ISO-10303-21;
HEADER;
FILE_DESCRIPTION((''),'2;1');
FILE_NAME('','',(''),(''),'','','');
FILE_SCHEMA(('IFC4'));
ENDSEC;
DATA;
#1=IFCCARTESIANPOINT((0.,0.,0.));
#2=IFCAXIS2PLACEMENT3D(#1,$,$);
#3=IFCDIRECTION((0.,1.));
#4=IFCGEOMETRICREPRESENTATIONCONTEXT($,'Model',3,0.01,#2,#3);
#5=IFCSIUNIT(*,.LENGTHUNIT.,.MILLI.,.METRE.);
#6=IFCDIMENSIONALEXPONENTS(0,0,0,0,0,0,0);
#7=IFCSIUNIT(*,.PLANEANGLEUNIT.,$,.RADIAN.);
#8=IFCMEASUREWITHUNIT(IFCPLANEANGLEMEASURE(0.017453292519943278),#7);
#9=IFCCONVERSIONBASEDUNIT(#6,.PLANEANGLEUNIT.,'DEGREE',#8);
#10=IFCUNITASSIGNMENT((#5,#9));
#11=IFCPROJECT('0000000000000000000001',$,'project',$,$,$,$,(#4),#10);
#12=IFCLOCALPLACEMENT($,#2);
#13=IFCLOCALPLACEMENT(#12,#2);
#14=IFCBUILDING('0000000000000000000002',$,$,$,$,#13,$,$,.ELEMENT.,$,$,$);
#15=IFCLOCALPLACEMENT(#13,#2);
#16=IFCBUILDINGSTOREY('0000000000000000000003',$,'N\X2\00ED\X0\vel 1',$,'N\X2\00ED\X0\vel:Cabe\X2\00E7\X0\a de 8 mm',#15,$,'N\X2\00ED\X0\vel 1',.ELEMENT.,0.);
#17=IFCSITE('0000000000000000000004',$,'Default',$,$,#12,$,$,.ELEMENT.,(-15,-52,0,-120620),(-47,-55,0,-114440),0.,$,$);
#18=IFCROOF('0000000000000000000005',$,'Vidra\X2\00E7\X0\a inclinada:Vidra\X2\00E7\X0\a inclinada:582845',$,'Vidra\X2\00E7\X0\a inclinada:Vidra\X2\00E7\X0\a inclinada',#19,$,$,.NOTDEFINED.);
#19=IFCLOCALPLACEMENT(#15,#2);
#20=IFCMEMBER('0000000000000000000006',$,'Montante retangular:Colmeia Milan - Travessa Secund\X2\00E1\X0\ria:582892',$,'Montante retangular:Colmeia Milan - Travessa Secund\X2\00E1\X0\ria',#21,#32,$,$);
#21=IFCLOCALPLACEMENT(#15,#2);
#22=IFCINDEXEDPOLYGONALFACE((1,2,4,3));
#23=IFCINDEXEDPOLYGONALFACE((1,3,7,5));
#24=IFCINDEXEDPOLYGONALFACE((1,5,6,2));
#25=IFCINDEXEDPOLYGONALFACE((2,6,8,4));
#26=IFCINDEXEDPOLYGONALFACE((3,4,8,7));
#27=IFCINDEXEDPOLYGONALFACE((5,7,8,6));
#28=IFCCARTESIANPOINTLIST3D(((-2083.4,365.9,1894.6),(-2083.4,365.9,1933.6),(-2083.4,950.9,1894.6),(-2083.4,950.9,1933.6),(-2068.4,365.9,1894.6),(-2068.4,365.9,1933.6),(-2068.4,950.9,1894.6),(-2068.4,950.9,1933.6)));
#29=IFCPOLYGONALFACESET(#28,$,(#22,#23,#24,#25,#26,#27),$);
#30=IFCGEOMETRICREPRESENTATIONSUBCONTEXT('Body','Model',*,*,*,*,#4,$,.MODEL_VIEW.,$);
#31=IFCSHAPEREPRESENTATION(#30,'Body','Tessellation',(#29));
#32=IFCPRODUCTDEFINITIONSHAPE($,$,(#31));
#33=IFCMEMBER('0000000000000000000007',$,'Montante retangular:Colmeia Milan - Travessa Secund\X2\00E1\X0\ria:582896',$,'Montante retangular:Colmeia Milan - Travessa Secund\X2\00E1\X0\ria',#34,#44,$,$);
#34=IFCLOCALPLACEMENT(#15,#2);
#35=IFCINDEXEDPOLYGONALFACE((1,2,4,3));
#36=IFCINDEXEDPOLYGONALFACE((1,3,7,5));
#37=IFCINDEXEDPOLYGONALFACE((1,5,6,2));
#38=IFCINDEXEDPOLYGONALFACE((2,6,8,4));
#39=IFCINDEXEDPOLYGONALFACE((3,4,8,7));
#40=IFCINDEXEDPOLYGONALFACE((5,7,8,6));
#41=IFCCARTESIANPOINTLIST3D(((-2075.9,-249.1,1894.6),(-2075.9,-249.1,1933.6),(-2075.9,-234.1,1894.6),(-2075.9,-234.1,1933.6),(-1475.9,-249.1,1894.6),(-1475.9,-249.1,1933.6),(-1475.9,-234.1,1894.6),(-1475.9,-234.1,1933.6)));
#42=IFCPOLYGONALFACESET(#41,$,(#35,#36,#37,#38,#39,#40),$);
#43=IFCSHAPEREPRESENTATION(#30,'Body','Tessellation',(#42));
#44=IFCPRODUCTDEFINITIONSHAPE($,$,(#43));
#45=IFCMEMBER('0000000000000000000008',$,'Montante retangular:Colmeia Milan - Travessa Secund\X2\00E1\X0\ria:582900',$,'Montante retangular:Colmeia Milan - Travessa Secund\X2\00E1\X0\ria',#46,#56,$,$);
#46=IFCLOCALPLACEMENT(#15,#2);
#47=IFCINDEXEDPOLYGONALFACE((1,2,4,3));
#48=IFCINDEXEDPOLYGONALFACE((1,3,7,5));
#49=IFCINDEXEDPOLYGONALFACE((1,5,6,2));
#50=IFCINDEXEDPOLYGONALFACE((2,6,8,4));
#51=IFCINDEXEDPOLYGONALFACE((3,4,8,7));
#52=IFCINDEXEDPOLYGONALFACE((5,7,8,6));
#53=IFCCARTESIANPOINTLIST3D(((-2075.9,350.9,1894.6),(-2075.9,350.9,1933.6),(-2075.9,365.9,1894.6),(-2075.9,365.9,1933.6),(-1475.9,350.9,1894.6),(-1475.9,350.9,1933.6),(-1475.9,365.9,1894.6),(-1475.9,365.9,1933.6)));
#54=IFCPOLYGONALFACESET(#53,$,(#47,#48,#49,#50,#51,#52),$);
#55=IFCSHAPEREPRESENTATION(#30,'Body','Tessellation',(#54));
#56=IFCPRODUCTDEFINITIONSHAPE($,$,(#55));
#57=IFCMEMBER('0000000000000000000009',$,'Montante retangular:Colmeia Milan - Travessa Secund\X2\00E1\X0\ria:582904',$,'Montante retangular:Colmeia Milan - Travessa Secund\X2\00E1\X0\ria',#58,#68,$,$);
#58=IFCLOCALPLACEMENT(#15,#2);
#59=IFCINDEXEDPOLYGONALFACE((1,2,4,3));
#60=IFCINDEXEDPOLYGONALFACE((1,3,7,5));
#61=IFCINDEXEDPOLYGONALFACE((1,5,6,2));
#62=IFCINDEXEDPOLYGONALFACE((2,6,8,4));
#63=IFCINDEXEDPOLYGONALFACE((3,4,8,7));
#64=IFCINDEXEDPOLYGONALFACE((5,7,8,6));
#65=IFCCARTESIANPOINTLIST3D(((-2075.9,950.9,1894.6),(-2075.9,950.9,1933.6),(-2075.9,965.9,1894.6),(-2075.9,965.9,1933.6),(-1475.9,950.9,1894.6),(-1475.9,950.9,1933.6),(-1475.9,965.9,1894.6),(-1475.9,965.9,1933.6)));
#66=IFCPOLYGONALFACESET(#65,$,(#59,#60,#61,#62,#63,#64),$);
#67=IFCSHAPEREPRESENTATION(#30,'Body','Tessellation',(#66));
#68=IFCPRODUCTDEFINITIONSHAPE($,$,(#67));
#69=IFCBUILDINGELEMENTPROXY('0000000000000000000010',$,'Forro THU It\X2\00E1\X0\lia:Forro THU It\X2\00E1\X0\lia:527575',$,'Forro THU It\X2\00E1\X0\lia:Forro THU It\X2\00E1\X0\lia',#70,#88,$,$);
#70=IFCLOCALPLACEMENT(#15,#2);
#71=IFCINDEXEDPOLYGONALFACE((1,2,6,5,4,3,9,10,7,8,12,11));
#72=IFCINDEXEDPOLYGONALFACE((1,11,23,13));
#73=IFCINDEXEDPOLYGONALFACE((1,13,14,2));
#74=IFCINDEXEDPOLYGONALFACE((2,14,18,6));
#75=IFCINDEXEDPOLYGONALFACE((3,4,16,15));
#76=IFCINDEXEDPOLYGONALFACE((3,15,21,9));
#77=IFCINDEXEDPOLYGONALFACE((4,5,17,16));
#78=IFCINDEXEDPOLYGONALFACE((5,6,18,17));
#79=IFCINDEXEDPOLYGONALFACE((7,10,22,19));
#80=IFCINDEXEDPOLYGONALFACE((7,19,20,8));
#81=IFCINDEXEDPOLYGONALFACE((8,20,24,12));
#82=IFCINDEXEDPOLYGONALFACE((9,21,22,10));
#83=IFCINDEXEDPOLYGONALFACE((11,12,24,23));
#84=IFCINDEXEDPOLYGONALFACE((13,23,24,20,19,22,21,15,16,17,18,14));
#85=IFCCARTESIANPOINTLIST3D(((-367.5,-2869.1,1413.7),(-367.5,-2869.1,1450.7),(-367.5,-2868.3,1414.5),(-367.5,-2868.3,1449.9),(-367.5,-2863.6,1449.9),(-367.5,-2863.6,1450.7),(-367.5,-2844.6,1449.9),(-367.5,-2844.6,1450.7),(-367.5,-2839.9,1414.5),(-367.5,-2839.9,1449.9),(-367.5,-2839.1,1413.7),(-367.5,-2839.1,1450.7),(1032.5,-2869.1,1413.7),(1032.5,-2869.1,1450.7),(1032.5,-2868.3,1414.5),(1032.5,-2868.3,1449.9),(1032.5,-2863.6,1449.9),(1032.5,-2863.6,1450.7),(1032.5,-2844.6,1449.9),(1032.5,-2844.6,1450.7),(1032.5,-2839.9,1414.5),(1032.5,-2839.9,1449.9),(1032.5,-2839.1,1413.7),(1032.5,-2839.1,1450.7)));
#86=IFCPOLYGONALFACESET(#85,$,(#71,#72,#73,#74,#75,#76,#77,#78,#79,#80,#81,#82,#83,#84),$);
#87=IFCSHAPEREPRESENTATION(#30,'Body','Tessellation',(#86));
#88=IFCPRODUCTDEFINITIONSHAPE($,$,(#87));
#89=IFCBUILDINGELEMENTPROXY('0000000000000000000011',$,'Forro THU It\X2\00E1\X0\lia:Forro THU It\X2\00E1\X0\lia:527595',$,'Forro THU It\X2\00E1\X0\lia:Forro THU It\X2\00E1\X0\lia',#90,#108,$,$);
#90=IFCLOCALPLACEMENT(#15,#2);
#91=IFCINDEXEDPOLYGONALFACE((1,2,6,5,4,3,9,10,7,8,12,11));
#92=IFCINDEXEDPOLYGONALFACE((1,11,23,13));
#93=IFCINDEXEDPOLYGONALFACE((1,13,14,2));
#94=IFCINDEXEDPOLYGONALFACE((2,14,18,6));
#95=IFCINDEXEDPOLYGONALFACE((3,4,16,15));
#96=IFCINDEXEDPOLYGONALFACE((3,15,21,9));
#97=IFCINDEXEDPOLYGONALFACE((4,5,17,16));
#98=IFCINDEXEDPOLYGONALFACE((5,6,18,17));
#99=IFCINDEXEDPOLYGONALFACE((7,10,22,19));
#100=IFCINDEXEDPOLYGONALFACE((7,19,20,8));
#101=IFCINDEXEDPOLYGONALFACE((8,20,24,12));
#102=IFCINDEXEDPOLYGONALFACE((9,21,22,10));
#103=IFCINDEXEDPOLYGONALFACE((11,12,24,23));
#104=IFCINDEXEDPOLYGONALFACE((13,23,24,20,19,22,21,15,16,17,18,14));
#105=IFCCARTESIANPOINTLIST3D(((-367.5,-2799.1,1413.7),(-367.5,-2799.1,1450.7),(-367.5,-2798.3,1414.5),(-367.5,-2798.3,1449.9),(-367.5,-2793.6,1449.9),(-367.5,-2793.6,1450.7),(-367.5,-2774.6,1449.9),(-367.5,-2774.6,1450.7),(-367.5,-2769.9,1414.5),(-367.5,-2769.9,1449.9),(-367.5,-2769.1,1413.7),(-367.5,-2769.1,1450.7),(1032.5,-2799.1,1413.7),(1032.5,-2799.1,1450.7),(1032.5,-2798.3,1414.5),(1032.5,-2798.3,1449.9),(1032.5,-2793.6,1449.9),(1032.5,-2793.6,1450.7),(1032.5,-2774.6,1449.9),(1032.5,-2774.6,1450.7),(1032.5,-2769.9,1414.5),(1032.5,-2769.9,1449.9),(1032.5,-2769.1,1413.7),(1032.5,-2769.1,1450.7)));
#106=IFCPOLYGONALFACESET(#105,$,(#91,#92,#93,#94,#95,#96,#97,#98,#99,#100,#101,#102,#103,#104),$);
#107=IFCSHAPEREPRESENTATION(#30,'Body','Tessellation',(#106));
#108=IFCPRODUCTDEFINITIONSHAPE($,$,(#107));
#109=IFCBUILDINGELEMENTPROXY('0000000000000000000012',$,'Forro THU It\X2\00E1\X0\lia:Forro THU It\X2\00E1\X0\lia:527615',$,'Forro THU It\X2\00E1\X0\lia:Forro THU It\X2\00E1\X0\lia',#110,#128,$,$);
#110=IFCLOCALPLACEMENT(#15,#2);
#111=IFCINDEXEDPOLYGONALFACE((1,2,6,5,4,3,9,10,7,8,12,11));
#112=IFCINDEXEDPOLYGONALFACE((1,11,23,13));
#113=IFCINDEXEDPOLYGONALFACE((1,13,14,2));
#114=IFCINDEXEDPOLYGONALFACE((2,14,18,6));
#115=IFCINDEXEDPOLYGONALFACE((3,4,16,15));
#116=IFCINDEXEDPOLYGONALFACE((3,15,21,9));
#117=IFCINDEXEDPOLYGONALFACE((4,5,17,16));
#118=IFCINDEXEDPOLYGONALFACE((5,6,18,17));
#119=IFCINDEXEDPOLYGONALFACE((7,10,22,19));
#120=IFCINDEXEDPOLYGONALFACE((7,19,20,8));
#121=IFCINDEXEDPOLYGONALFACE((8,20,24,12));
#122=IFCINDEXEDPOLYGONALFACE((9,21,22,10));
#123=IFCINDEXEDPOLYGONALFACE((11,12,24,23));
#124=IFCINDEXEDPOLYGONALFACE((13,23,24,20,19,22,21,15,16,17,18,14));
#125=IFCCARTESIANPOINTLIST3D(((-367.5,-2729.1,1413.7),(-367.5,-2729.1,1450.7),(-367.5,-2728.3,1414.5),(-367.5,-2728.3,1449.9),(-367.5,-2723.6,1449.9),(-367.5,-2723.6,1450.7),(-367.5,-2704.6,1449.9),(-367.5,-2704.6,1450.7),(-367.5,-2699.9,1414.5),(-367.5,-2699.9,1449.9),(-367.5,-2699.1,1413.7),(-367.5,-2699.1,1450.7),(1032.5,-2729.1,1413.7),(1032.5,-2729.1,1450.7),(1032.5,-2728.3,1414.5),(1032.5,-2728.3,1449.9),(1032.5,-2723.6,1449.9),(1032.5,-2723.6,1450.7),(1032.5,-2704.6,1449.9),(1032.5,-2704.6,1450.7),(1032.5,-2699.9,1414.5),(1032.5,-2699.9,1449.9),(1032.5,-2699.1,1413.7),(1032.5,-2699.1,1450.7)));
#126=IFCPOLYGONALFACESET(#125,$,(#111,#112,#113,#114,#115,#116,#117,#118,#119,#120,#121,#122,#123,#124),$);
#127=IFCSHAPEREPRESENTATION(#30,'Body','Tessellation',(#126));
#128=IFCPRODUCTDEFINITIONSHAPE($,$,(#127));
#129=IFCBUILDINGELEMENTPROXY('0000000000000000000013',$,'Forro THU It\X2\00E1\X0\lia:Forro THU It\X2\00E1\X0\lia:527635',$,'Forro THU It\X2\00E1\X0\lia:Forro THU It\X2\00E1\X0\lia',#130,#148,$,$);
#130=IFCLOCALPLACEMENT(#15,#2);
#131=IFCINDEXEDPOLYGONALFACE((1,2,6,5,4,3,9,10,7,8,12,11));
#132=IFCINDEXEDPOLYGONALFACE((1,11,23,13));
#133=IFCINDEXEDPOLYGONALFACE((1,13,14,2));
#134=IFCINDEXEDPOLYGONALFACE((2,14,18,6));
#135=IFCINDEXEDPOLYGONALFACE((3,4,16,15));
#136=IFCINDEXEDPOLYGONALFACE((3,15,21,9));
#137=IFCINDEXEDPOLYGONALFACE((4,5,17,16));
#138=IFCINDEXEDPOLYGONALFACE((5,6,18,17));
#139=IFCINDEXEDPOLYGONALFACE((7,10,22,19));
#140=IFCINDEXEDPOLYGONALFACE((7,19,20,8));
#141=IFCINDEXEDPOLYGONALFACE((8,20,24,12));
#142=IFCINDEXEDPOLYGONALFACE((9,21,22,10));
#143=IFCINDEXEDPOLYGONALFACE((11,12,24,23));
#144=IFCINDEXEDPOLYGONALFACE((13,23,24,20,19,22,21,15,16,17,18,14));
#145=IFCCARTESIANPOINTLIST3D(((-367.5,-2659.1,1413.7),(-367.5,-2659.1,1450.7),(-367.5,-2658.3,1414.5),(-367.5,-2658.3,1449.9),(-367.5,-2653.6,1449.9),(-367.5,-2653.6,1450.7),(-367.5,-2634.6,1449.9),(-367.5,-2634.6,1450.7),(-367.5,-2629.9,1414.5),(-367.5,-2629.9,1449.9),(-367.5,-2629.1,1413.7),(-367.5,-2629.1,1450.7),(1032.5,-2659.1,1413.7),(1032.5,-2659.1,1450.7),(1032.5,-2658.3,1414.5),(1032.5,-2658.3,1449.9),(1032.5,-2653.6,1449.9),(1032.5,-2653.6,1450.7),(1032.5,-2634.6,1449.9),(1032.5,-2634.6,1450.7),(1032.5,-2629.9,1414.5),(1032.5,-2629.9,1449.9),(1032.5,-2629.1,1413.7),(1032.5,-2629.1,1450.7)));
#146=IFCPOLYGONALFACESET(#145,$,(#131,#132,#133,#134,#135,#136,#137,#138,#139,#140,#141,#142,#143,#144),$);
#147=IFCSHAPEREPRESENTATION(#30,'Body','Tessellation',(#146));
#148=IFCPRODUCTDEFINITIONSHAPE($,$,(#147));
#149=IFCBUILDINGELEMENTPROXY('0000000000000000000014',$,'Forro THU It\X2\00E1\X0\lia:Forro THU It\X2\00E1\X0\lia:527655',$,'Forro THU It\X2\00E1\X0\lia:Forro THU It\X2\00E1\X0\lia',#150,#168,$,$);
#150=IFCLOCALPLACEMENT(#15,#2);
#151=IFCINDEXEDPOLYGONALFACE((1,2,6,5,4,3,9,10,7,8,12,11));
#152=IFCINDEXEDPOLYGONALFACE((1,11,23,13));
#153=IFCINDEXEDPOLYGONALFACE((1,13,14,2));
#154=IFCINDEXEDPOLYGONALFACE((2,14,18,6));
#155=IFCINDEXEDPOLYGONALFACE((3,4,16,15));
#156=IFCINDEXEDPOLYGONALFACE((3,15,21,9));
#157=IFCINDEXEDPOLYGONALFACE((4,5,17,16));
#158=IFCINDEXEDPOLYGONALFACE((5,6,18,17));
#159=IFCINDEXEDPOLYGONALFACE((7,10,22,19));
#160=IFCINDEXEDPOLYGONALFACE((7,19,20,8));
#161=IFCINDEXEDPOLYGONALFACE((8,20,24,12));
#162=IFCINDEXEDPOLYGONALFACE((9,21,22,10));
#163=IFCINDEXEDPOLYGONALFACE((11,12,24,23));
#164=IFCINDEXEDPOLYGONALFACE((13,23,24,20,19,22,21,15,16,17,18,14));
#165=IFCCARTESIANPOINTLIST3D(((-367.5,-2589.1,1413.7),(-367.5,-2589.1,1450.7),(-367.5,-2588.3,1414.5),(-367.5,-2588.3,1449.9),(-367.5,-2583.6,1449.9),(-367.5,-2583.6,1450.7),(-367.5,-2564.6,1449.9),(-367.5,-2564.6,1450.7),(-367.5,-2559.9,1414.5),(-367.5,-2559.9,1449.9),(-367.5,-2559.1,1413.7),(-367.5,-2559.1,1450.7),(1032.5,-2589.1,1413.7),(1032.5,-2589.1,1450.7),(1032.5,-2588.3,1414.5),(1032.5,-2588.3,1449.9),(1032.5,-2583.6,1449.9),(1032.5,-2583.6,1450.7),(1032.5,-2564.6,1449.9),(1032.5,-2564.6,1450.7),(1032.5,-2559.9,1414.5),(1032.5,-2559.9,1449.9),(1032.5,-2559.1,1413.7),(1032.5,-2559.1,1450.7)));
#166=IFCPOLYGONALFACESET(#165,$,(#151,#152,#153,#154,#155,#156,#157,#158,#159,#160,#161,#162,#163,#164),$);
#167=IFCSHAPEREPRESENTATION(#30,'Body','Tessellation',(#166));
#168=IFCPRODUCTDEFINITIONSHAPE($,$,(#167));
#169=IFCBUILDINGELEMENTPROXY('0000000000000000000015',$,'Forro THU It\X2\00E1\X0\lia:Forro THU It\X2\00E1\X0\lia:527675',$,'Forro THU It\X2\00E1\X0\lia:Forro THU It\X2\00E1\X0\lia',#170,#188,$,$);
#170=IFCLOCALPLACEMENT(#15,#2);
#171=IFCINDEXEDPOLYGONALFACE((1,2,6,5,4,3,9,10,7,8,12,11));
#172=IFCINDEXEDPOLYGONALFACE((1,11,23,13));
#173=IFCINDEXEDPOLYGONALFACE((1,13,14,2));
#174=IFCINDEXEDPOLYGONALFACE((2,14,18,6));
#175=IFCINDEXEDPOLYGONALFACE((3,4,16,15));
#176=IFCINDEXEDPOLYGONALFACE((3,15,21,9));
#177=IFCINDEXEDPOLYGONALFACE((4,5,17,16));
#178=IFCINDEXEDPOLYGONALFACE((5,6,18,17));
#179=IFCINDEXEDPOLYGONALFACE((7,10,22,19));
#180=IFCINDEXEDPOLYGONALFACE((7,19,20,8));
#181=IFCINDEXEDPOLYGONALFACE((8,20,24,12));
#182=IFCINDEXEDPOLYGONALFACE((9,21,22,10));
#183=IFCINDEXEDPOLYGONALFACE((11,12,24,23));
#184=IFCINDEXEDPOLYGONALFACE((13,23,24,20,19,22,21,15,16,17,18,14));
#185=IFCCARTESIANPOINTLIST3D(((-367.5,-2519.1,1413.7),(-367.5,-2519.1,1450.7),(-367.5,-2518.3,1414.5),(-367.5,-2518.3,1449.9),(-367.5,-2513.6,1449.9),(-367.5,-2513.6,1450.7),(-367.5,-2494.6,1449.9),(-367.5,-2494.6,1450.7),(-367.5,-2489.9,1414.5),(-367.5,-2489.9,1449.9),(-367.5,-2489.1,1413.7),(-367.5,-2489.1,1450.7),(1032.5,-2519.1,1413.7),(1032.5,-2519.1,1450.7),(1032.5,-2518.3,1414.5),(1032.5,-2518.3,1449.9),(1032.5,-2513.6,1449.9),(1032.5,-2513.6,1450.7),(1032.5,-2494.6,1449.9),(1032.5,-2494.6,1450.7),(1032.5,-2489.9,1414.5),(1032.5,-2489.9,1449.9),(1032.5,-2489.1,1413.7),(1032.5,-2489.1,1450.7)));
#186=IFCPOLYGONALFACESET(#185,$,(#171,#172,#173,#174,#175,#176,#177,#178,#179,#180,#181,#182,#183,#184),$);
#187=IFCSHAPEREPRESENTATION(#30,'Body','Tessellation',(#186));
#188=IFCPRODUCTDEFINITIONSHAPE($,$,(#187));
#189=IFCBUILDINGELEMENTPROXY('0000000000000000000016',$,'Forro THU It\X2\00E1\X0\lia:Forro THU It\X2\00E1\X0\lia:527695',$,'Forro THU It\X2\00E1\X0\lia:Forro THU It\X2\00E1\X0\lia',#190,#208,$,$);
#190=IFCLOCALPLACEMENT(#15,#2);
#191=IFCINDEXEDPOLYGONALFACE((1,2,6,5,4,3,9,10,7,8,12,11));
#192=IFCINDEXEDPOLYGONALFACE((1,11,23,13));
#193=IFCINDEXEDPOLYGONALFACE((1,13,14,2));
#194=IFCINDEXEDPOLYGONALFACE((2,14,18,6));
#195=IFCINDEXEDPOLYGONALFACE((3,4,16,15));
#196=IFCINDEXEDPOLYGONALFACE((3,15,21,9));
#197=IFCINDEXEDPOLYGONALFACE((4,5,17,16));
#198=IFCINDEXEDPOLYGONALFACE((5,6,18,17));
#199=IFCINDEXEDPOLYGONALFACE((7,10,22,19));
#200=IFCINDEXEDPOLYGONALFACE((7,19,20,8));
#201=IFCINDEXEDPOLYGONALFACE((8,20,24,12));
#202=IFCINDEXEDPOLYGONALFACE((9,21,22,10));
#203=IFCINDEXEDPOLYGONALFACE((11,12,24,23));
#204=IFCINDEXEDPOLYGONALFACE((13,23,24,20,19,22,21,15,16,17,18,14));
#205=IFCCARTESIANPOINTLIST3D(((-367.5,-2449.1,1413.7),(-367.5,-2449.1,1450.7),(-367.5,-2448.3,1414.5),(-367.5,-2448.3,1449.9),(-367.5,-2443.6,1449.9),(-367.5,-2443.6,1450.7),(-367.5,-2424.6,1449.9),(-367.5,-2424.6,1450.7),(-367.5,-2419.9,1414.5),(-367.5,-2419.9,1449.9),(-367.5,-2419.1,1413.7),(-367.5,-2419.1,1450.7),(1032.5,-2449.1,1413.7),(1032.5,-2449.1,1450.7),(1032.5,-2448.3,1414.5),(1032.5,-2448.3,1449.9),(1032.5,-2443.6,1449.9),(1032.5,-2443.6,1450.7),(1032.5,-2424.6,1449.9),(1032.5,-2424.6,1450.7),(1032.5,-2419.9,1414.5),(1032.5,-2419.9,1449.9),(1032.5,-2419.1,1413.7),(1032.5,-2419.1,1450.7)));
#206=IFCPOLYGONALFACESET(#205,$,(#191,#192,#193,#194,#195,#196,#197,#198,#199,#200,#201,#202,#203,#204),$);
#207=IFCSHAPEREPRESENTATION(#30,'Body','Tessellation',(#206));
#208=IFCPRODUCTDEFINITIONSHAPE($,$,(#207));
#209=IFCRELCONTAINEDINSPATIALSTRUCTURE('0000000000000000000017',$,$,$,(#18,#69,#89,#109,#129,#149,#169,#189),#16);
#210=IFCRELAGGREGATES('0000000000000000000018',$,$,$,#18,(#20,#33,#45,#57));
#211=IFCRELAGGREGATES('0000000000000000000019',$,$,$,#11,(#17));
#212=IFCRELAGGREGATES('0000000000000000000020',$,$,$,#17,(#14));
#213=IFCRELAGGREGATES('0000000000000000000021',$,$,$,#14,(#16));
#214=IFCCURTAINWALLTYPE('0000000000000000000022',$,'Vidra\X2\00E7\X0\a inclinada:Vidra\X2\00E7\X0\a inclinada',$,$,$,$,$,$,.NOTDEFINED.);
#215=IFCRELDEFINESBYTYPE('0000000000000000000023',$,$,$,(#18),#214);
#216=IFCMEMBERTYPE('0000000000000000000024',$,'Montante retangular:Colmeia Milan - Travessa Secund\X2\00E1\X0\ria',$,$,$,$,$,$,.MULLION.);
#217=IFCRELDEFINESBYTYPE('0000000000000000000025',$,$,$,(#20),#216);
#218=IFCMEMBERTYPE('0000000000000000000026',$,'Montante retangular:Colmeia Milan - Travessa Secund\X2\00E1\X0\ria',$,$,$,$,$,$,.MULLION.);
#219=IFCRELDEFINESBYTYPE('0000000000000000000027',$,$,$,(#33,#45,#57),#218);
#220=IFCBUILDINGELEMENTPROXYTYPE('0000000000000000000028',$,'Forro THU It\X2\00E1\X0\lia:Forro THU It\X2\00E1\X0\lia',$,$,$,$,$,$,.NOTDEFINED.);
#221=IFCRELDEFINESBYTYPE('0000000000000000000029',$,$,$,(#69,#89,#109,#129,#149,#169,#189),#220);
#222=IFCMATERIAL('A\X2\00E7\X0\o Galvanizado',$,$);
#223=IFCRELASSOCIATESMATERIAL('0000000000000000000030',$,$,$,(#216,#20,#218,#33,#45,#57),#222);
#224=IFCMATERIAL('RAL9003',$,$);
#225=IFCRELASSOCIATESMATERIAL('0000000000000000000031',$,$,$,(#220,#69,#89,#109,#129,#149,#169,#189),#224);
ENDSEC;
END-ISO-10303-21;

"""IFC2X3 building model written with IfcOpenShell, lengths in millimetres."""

from ifc_helpers import new_model, entity, si_unit, converted_unit, direction, frame, origin, origin_2d_with_axis, place, context, subcontext, project, spatial, polyline, rectangle, outline, extrude, source, transform, mapped, material, type_object, type_shapes, element, aggregate, save


model = new_model("IFC2X3")

# Units and contexts
model_context = context("Model", 3, precision=0.01, world=origin(), true_north=direction((0.0, 1.0)))
body_context = subcontext(model_context, "Body", "Model", "MODEL_VIEW")
ifc_project = project(units=[si_unit("LENGTHUNIT", "METRE", prefix="MILLI"), converted_unit("PLANEANGLEUNIT", "DEGREE", entity("IfcPlaneAngleMeasure", 0.017453292519943278), si_unit("PLANEANGLEUNIT", "RADIAN"), dimensions=[0, 0, 0, 0, 0, 0, 0])], contexts=[model_context])

# Site, building, storey
site_placement = place(None, origin())
site = spatial("IfcSite", under=ifc_project, at=site_placement, Name="Default", CompositionType="ELEMENT", RefLatitude=(-15, -52, 0, -120620), RefLongitude=(-47, -55, 0, -114440), RefElevation=0.0)
building_placement = place(site_placement, origin())
building = spatial("IfcBuilding", under=site, at=building_placement, CompositionType="ELEMENT")
storey_placement = place(building_placement, origin())
storey = spatial("IfcBuildingStorey", under=building, at=storey_placement, Name="Nível 1", ObjectType="Nível:Cabeça de 8 mm", LongName="Nível 1", CompositionType="ELEMENT", Elevation=0.0)

# Roof, members
curtain_wall_type = type_object("IfcCurtainWallType", Name="Vidraça inclinada:Vidraça inclinada", PredefinedType="NOTDEFINED")
roof_placement = place(storey_placement, origin())
roof = element("IfcRoof", 1, at=roof_placement, inside=storey, type_object=curtain_wall_type, Name="Vidraça inclinada:Vidraça inclinada:582845", ObjectType="Vidraça inclinada:Vidraça inclinada", ShapeType="NOTDEFINED")
ifc_material_1 = material(Name="Aço Galvanizado")
member_type_1 = type_object("IfcMemberType", Name="Montante retangular:Colmeia Milan - Travessa Secundária", PredefinedType="MULLION", material=ifc_material_1)
shared_shape_1 = source(origin(), body_context, "Body", "SweptSolid", [
    extrude(rectangle(XDim=15.0, YDim=39.0, at=origin_2d_with_axis()), frame((0.0, -19.5, -585.0), z_axis=(0.0, 0.0, 1.0), x_axis=(-1.0, 0.0, 0.0)), (0.0, 0.0, 1.0), 585.0),
])
type_shapes(member_type_1, [shared_shape_1])
member_1_placement = place(roof_placement, frame((-2075.9, 950.9, 1894.6), z_axis=(0.0, 1.0, 0.0), x_axis=(1.0, 0.0, 0.0)))
member_1 = element("IfcMember", 2, at=member_1_placement, type_object=member_type_1, material=ifc_material_1, Name="Montante retangular:Colmeia Milan - Travessa Secundária:582892", ObjectType="Montante retangular:Colmeia Milan - Travessa Secundária", context=body_context, shape_type="MappedRepresentation", body=[
    mapped(shared_shape_1, transform((0.0, 0.0, 0.0), scale=1.0)),
])
member_type_2 = type_object("IfcMemberType", Name="Montante retangular:Colmeia Milan - Travessa Secundária", PredefinedType="MULLION", material=ifc_material_1)
shared_shape_2 = source(origin(), body_context, "Body", "SweptSolid", [
    extrude(rectangle(XDim=15.0, YDim=39.0, at=origin_2d_with_axis()), frame((0.0, -19.5, -600.0), z_axis=(0.0, 0.0, 1.0), x_axis=(-1.0, 0.0, 0.0)), (0.0, 0.0, 1.0), 600.0),
])
type_shapes(member_type_2, [shared_shape_2])
member_2_placement = place(roof_placement, frame((-2075.9, -241.6, 1894.6), z_axis=(-1.0, 0.0, 0.0), x_axis=(0.0, 1.0, 0.0)))
member_2 = element("IfcMember", 3, at=member_2_placement, type_object=member_type_2, material=ifc_material_1, Name="Montante retangular:Colmeia Milan - Travessa Secundária:582896", ObjectType="Montante retangular:Colmeia Milan - Travessa Secundária", context=body_context, shape_type="MappedRepresentation", body=[
    mapped(shared_shape_2, transform((0.0, 0.0, 0.0), scale=1.0)),
])
member_3_placement = place(roof_placement, frame((-2075.9, 358.4, 1894.6), z_axis=(-1.0, 0.0, 0.0), x_axis=(0.0, 1.0, 0.0)))
member_3 = element("IfcMember", 4, at=member_3_placement, type_object=member_type_2, material=ifc_material_1, Name="Montante retangular:Colmeia Milan - Travessa Secundária:582900", ObjectType="Montante retangular:Colmeia Milan - Travessa Secundária", context=body_context, shape_type="MappedRepresentation", body=[
    mapped(shared_shape_2, transform((0.0, 0.0, 0.0), scale=1.0)),
])
member_4_placement = place(roof_placement, frame((-2075.9, 958.4, 1894.6), z_axis=(-1.0, 0.0, 0.0), x_axis=(0.0, 1.0, 0.0)))
member_4 = element("IfcMember", 5, at=member_4_placement, type_object=member_type_2, material=ifc_material_1, Name="Montante retangular:Colmeia Milan - Travessa Secundária:582904", ObjectType="Montante retangular:Colmeia Milan - Travessa Secundária", context=body_context, shape_type="MappedRepresentation", body=[
    mapped(shared_shape_2, transform((0.0, 0.0, 0.0), scale=1.0)),
])
aggregate(roof, [member_1, member_2, member_3, member_4])

# Building element proxies
ifc_material_2 = material(Name="RAL9003")
building_element_proxy_type = type_object("IfcBuildingElementProxyType", Name="Forro THU Itália:Forro THU Itália", PredefinedType="NOTDEFINED", material=ifc_material_2)
shared_shape_3 = source(origin(), body_context, "Body", "SweptSolid", [
    extrude(outline(polyline([(-12.5, -15.0), (24.5, -15.0), (24.5, 15.0), (-12.5, 15.0), (-12.5, 9.5), (-11.7, 9.5), (-11.7, 14.2), (23.7, 14.2), (23.7, -14.2), (-11.7, -14.2), (-11.7, -9.5), (-12.5, -9.5), (-12.5, -15.0)])), frame((0.0, 15.0, -12.5), z_axis=(1.0, 0.0, 0.0), x_axis=(0.0, 0.0, -1.0)), (0.0, 0.0, 1.0), 1400.0),
])
type_shapes(building_element_proxy_type, [shared_shape_3])
for number, where, name in (
    (6, (-367.5, -2869.1, 1450.7), "Forro THU Itália:Forro THU Itália:527575"),
    (7, (-367.5, -2799.1, 1450.7), "Forro THU Itália:Forro THU Itália:527595"),
    (8, (-367.5, -2729.1, 1450.7), "Forro THU Itália:Forro THU Itália:527615"),
    (9, (-367.5, -2659.1, 1450.7), "Forro THU Itália:Forro THU Itália:527635"),
    (10, (-367.5, -2589.1, 1450.7), "Forro THU Itália:Forro THU Itália:527655"),
    (11, (-367.5, -2519.1, 1450.7), "Forro THU Itália:Forro THU Itália:527675"),
    (12, (-367.5, -2449.1, 1450.7), "Forro THU Itália:Forro THU Itália:527695"),
):
    element("IfcBuildingElementProxy", number, at=place(storey_placement, frame(where)), inside=storey, type_object=building_element_proxy_type, material=ifc_material_2, Name=name, ObjectType="Forro THU Itália:Forro THU Itália", context=body_context, shape_type="MappedRepresentation", body=[
        mapped(shared_shape_3, transform((0.0, 0.0, 0.0), scale=1.0)),
    ])

save(model, "model.ifc")
